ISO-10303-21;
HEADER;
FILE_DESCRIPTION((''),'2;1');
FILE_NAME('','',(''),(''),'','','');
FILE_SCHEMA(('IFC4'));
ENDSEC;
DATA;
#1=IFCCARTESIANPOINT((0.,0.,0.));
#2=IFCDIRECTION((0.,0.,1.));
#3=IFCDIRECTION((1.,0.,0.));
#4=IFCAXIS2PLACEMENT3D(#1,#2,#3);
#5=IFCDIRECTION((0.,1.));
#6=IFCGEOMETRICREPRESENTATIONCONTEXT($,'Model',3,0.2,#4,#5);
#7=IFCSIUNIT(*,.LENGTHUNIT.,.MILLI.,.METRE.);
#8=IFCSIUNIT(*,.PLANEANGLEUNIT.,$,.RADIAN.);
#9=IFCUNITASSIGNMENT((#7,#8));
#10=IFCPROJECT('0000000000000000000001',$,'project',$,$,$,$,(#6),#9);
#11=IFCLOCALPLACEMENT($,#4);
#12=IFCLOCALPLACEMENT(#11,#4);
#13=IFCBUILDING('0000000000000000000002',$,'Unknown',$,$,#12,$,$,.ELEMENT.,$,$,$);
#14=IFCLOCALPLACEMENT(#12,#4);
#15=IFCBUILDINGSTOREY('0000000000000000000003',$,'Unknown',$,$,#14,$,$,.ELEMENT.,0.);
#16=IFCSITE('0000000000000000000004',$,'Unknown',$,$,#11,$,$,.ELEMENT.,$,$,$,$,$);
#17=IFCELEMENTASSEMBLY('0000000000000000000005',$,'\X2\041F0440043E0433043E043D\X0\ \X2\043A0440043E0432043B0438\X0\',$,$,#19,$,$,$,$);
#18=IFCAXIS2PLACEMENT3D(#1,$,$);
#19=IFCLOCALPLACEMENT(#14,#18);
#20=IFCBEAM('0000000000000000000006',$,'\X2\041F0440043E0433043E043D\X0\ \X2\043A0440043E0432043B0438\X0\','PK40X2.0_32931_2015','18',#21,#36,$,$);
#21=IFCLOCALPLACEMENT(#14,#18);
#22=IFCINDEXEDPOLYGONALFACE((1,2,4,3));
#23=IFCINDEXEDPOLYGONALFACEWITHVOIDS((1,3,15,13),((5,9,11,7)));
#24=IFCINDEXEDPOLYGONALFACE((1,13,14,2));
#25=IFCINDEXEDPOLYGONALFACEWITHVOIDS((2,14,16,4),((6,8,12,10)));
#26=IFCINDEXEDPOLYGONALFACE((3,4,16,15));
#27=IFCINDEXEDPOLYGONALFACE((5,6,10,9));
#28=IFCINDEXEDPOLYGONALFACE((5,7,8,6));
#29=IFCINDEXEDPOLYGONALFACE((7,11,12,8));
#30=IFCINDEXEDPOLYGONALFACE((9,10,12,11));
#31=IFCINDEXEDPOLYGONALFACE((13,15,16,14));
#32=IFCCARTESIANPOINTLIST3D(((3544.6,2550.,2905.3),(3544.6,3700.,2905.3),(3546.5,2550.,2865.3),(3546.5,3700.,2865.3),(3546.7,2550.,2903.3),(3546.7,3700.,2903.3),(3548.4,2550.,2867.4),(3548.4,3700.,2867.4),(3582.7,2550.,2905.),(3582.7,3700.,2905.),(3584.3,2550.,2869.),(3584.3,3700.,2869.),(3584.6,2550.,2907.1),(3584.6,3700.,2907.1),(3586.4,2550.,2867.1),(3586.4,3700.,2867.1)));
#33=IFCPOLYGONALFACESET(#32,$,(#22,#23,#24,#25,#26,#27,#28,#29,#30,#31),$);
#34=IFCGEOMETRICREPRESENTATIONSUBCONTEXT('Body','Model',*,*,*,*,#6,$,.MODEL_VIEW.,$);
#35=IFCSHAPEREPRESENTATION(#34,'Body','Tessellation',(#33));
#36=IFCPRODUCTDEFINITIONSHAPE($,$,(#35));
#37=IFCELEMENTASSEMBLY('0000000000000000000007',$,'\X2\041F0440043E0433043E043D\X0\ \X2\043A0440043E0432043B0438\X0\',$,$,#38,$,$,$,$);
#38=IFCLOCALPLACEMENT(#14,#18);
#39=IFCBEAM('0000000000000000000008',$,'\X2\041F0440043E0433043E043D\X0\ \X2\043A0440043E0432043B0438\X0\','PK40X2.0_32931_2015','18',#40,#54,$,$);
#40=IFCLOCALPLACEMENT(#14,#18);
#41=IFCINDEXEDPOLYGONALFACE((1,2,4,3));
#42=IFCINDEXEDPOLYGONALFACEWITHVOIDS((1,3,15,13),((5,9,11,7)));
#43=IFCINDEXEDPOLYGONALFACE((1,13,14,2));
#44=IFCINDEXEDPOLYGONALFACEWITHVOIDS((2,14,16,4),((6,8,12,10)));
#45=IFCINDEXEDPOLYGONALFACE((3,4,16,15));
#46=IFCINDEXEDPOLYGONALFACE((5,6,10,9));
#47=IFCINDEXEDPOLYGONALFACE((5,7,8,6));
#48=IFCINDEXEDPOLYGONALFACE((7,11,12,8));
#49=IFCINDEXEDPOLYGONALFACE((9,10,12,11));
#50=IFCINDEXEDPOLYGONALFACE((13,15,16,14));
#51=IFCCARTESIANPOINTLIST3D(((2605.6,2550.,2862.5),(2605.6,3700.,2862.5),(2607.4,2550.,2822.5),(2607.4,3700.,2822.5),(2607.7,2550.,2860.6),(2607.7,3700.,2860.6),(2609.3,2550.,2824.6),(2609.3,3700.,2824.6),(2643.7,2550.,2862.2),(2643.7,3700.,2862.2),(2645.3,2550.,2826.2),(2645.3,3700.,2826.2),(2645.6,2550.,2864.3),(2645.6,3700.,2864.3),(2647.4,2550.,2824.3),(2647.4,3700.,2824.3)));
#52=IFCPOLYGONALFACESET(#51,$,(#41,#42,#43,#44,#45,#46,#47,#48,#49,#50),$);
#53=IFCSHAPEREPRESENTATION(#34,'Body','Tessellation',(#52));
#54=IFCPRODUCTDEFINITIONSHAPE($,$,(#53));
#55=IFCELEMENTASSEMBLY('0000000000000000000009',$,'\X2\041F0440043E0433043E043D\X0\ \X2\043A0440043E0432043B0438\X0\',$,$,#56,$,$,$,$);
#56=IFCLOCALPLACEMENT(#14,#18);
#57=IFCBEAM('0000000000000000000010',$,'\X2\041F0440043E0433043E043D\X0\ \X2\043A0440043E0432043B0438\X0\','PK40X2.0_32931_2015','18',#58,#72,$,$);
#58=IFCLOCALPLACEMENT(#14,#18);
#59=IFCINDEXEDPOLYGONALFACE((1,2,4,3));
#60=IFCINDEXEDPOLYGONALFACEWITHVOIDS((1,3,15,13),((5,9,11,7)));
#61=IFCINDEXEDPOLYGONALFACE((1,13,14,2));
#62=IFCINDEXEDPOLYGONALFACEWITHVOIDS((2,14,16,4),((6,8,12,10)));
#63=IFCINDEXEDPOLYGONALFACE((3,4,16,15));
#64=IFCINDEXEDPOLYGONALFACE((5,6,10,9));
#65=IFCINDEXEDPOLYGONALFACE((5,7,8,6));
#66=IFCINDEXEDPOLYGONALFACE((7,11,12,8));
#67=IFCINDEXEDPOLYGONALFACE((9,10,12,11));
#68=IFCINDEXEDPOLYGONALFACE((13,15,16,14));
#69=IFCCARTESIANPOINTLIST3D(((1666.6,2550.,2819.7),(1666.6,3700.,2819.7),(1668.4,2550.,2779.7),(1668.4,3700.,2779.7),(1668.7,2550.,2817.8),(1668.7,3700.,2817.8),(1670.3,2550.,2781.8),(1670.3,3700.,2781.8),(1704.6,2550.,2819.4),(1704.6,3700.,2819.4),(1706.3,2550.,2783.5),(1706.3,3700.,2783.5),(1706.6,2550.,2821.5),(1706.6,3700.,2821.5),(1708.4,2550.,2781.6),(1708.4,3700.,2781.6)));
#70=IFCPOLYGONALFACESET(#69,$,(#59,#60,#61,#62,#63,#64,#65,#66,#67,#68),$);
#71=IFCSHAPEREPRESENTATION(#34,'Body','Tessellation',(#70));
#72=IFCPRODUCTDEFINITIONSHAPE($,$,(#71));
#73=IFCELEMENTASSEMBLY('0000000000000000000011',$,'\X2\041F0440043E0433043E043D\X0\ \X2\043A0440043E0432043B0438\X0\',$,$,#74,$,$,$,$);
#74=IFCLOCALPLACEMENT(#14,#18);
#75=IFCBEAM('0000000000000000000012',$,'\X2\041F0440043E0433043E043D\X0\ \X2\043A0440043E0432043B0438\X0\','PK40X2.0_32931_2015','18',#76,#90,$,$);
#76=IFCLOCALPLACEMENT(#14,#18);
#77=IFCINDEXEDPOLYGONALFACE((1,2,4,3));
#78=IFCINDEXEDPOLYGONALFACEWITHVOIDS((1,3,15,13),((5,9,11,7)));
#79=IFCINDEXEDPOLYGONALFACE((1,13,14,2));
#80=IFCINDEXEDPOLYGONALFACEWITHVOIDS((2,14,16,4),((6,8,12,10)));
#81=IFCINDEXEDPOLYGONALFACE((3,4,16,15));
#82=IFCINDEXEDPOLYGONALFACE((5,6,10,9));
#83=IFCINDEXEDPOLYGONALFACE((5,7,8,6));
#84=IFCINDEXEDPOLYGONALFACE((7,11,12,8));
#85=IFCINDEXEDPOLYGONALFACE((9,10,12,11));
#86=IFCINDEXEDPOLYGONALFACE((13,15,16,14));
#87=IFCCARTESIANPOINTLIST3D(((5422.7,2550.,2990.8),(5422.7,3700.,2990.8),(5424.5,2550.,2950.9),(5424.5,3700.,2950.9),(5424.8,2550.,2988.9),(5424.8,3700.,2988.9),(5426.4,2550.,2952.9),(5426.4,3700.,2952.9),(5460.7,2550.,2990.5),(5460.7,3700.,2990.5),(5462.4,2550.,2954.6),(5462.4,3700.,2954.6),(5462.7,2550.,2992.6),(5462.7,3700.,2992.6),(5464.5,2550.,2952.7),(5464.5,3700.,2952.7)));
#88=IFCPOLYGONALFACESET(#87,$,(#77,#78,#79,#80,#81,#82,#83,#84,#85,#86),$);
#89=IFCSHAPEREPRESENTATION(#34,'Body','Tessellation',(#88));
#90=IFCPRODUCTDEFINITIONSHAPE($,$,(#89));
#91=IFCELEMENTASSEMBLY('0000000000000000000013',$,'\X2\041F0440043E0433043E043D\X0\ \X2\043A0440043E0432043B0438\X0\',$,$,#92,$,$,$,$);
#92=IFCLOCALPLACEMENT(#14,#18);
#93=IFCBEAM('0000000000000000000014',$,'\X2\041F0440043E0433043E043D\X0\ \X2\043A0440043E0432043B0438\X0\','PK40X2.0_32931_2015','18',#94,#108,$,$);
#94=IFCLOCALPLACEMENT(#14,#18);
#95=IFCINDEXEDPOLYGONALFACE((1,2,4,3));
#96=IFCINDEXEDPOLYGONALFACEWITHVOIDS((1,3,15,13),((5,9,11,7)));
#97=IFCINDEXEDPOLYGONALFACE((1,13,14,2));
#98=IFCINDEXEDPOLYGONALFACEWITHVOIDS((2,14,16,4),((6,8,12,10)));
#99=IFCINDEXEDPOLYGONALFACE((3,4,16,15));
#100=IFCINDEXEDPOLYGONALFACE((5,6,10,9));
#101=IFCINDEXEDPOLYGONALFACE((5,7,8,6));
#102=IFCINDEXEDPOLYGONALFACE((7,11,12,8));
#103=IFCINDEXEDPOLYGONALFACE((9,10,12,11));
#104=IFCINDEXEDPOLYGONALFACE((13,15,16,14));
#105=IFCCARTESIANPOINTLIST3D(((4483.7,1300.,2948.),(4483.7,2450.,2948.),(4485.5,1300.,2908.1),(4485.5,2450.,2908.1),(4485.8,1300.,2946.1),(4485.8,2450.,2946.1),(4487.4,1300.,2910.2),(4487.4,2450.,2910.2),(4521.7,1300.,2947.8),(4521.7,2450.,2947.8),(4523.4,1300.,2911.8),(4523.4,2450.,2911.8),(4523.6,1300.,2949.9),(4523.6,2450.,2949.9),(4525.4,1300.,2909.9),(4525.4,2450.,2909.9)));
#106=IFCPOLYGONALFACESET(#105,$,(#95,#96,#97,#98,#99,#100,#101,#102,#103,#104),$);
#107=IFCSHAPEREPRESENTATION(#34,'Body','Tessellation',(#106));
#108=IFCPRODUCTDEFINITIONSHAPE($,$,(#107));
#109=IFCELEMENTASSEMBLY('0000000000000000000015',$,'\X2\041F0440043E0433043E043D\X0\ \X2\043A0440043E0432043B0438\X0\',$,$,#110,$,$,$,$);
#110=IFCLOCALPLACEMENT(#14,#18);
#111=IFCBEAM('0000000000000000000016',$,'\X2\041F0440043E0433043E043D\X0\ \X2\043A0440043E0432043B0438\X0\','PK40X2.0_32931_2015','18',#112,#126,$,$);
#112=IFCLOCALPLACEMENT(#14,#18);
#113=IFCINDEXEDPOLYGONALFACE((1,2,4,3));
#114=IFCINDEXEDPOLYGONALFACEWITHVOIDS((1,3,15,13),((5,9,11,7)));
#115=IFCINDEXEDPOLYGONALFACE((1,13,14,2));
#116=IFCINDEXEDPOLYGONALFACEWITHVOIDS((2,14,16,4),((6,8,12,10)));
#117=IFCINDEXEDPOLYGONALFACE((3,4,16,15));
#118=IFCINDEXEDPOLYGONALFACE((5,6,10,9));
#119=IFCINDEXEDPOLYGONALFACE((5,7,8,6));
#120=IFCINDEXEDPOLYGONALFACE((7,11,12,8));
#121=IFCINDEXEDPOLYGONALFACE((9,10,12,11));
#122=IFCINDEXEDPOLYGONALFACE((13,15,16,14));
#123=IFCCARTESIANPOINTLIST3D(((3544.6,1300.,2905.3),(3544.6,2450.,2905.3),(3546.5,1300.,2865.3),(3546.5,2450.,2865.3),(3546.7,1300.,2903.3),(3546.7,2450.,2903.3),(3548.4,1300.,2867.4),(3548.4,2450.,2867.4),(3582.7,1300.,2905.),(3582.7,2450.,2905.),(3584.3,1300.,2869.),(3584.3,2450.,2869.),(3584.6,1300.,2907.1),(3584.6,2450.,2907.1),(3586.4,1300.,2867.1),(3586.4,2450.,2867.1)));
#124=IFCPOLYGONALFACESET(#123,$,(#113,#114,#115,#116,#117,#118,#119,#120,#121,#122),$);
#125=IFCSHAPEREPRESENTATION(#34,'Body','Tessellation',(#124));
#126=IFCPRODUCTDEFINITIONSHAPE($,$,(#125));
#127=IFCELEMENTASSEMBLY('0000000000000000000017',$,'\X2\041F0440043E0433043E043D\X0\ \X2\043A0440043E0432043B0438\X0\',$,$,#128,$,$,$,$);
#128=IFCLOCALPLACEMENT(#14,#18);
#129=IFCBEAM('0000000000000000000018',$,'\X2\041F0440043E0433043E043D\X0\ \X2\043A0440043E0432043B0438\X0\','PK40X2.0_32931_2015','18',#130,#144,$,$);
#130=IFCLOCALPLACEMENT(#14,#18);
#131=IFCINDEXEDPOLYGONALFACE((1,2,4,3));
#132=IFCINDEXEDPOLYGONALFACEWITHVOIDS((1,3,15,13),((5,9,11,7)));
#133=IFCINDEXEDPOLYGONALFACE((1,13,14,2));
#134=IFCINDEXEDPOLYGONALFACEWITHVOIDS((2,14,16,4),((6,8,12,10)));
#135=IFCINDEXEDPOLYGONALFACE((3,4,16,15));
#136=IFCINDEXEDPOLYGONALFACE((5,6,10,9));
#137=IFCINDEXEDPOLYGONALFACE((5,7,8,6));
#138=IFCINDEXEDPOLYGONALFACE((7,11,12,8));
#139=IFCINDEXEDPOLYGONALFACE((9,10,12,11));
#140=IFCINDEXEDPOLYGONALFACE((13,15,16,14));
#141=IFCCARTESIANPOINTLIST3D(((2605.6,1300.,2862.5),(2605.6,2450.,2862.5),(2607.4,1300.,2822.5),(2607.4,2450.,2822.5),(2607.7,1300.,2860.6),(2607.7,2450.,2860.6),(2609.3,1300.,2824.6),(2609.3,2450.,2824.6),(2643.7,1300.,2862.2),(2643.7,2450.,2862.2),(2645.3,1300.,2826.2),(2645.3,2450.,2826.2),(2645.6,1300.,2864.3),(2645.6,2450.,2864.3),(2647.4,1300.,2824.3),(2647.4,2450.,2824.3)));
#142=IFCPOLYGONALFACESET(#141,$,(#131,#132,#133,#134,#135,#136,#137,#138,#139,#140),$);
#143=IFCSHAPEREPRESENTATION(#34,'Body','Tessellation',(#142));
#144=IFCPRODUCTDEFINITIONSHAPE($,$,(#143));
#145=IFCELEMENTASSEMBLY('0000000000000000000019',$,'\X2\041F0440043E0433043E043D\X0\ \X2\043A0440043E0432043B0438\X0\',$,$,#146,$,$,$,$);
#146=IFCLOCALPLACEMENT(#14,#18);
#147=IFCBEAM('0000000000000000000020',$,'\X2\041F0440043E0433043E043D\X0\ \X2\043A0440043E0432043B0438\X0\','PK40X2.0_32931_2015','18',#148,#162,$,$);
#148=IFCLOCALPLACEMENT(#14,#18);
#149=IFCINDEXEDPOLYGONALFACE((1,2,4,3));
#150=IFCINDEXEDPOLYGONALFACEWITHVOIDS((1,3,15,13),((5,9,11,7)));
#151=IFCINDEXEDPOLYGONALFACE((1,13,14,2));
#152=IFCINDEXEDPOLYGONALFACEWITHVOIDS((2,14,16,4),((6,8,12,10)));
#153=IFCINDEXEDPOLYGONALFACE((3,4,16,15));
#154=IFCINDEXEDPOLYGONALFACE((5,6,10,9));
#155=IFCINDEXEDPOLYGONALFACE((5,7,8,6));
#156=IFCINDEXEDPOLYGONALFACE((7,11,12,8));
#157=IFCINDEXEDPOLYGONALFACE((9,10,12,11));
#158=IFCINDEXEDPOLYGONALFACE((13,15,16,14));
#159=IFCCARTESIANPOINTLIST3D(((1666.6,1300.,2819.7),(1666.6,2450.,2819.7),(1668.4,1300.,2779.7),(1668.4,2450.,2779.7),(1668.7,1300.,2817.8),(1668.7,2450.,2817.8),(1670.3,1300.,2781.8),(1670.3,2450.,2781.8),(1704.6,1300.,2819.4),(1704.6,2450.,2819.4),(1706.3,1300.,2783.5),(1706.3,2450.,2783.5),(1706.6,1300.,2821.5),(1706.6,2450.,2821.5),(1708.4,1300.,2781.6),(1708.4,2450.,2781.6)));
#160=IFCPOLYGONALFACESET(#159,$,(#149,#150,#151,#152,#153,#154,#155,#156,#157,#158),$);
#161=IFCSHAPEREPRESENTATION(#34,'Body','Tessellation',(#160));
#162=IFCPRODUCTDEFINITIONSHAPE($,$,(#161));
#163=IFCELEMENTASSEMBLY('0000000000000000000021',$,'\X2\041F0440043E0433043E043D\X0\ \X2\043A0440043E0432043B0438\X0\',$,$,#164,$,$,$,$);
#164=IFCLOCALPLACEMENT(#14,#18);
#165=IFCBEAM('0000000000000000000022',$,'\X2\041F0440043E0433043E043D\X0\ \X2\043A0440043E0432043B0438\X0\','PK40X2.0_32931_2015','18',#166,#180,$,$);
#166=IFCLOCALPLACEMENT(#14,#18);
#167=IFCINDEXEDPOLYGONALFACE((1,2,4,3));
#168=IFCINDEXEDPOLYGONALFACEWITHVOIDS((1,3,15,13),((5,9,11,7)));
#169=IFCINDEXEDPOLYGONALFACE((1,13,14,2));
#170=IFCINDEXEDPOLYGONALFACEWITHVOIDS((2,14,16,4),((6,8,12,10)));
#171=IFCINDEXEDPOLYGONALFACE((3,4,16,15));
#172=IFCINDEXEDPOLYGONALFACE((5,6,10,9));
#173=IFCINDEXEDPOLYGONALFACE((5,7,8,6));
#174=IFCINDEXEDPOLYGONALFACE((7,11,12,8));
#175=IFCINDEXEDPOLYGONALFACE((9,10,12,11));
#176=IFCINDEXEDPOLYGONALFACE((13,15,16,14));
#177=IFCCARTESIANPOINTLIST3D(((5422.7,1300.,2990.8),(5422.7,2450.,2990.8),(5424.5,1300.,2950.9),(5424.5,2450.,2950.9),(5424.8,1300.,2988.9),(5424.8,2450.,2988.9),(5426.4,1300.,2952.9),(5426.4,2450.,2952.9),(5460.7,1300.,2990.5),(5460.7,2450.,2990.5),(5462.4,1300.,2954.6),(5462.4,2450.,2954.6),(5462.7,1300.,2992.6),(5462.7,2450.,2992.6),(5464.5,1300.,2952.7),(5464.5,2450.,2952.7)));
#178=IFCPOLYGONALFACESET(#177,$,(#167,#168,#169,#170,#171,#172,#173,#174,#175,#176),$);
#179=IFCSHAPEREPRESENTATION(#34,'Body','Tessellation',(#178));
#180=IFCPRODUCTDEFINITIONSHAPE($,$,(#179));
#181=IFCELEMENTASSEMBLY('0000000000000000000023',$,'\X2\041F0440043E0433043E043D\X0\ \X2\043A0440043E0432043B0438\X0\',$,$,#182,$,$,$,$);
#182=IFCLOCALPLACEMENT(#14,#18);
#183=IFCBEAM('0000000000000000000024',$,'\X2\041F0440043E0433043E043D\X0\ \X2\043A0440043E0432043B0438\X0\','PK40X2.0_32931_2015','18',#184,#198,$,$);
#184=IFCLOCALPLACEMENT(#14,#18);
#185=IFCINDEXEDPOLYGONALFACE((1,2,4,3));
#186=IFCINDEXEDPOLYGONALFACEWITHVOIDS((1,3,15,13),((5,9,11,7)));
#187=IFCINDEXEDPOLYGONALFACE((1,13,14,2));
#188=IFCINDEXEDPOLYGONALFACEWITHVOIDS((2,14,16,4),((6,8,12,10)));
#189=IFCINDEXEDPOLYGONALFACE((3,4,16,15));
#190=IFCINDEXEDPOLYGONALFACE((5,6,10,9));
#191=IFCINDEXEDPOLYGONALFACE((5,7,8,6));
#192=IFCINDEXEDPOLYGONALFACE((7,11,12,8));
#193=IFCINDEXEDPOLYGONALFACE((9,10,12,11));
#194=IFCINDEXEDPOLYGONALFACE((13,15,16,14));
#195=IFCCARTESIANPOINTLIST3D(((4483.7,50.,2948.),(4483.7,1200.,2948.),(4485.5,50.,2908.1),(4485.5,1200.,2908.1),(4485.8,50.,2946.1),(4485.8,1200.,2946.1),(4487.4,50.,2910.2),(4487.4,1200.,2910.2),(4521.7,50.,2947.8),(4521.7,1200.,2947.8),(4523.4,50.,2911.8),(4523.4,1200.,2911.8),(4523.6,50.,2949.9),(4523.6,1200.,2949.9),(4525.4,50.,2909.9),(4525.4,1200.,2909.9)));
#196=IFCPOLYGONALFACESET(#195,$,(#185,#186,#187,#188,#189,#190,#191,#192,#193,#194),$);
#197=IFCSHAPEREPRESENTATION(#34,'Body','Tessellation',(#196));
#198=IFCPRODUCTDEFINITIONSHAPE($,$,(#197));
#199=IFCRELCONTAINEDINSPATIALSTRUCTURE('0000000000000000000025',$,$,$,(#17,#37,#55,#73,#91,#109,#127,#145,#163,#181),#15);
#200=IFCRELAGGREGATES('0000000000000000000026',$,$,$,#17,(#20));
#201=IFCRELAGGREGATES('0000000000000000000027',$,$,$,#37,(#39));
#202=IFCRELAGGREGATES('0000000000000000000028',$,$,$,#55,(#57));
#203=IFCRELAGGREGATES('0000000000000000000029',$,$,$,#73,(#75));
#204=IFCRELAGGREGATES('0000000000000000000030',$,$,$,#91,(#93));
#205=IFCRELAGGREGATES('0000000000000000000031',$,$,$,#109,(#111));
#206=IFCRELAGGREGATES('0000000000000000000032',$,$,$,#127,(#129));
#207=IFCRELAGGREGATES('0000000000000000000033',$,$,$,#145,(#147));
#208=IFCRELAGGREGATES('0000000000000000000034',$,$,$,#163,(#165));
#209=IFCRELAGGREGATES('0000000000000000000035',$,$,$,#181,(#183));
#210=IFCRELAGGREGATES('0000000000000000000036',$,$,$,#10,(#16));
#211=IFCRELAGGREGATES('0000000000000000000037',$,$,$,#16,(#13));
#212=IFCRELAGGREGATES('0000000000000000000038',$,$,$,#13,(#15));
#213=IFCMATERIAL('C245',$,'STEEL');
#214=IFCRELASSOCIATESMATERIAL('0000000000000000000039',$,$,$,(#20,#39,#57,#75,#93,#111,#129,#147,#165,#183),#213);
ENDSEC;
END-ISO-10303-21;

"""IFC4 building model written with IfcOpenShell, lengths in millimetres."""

from ifc_helpers import new_model, si_unit, direction, frame, origin_with_axes, place, context, subcontext, project, spatial, line, indexed_curve, outline, extrude, material, element, aggregate, save


model = new_model("IFC4")

# Units and contexts
model_context = context("Model", 3, precision=0.2, world=origin_with_axes(), true_north=direction((0.0, 1.0)))
body_context = subcontext(model_context, "Body", "Model", "MODEL_VIEW")
ifc_project = project(units=[si_unit("LENGTHUNIT", "METRE", prefix="MILLI"), si_unit("PLANEANGLEUNIT", "RADIAN")], contexts=[model_context])

# Site, building, storey
site_placement = place(None, origin_with_axes())
site = spatial("IfcSite", under=ifc_project, at=site_placement, Name="Unknown", CompositionType="ELEMENT")
building_placement = place(site_placement, origin_with_axes())
building = spatial("IfcBuilding", under=site, at=building_placement, Name="Unknown", CompositionType="ELEMENT")
storey_placement = place(building_placement, origin_with_axes())
storey = spatial("IfcBuildingStorey", under=building, at=storey_placement, Name="Unknown", CompositionType="ELEMENT", Elevation=0.0)

# Shared definitions
ifc_material = material(Name="C245", Category="STEEL")

# Element assemblies, beams
assembly_1_placement = place(storey_placement, frame((3565.5, 3700.0, 2886.2), z_axis=(-0.998964, 0.0, -0.045508), x_axis=(0.0, -1.0, 0.0)))
assembly_1 = element("IfcElementAssembly", 1, at=assembly_1_placement, inside=storey, Name="Прогон кровли")
beam_1_placement = place(assembly_1_placement, origin_with_axes())
beam_1 = element("IfcBeam", 2, at=beam_1_placement, material=ifc_material, Name="Прогон кровли", Description="PK40X2.0_32931_2015", ObjectType="18", context=body_context, shape_type="SolidModel", body=[
    extrude(outline(indexed_curve([(-20.0, -20.0), (20.0, -20.0), (20.0, 20.0), (-20.0, 20.0)], segments=[line(1, 2, 3, 4, 1)]), holes=[indexed_curve([(-18.0, -18.0), (-18.0, 18.0), (18.0, 18.0), (18.0, -18.0)], segments=[line(1, 2, 3, 4, 1)])]), frame((0.0, 0.0, 0.0), z_axis=(-1.0, 0.0, 0.0), x_axis=(0.0, 0.0, 1.0)), (0.0, 0.0, -1.0), 1150.0),
])
aggregate(assembly_1, [beam_1])
assembly_2_placement = place(storey_placement, frame((2626.5, 3700.0, 2843.4), z_axis=(-0.998964, 0.0, -0.045508), x_axis=(0.0, -1.0, 0.0)))
assembly_2 = element("IfcElementAssembly", 3, at=assembly_2_placement, inside=storey, Name="Прогон кровли")
beam_2_placement = place(assembly_2_placement, origin_with_axes())
beam_2 = element("IfcBeam", 4, at=beam_2_placement, material=ifc_material, Name="Прогон кровли", Description="PK40X2.0_32931_2015", ObjectType="18", context=body_context, shape_type="SolidModel", body=[
    extrude(outline(indexed_curve([(-20.0, -20.0), (20.0, -20.0), (20.0, 20.0), (-20.0, 20.0)], segments=[line(1, 2, 3, 4, 1)]), holes=[indexed_curve([(-18.0, -18.0), (-18.0, 18.0), (18.0, 18.0), (18.0, -18.0)], segments=[line(1, 2, 3, 4, 1)])]), frame((0.0, 0.0, 0.0), z_axis=(-1.0, 0.0, 0.0), x_axis=(0.0, 0.0, 1.0)), (0.0, 0.0, -1.0), 1150.0),
])
aggregate(assembly_2, [beam_2])
assembly_3_placement = place(storey_placement, frame((1687.5, 3700.0, 2800.6), z_axis=(-0.998964, 0.0, -0.045508), x_axis=(0.0, -1.0, 0.0)))
assembly_3 = element("IfcElementAssembly", 5, at=assembly_3_placement, inside=storey, Name="Прогон кровли")
beam_3_placement = place(assembly_3_placement, origin_with_axes())
beam_3 = element("IfcBeam", 6, at=beam_3_placement, material=ifc_material, Name="Прогон кровли", Description="PK40X2.0_32931_2015", ObjectType="18", context=body_context, shape_type="SolidModel", body=[
    extrude(outline(indexed_curve([(-20.0, -20.0), (20.0, -20.0), (20.0, 20.0), (-20.0, 20.0)], segments=[line(1, 2, 3, 4, 1)]), holes=[indexed_curve([(-18.0, -18.0), (-18.0, 18.0), (18.0, 18.0), (18.0, -18.0)], segments=[line(1, 2, 3, 4, 1)])]), frame((0.0, 0.0, 0.0), z_axis=(-1.0, 0.0, 0.0), x_axis=(0.0, 0.0, 1.0)), (0.0, 0.0, -1.0), 1150.0),
])
aggregate(assembly_3, [beam_3])
assembly_4_placement = place(storey_placement, frame((5443.6, 3700.0, 2971.7), z_axis=(-0.998964, 0.0, -0.045508), x_axis=(0.0, -1.0, 0.0)))
assembly_4 = element("IfcElementAssembly", 7, at=assembly_4_placement, inside=storey, Name="Прогон кровли")
beam_4_placement = place(assembly_4_placement, origin_with_axes())
beam_4 = element("IfcBeam", 8, at=beam_4_placement, material=ifc_material, Name="Прогон кровли", Description="PK40X2.0_32931_2015", ObjectType="18", context=body_context, shape_type="SolidModel", body=[
    extrude(outline(indexed_curve([(-20.0, -20.0), (20.0, -20.0), (20.0, 20.0), (-20.0, 20.0)], segments=[line(1, 2, 3, 4, 1)]), holes=[indexed_curve([(-18.0, -18.0), (-18.0, 18.0), (18.0, 18.0), (18.0, -18.0)], segments=[line(1, 2, 3, 4, 1)])]), frame((0.0, 0.0, 0.0), z_axis=(-1.0, 0.0, 0.0), x_axis=(0.0, 0.0, 1.0)), (0.0, 0.0, -1.0), 1150.0),
])
aggregate(assembly_4, [beam_4])
assembly_5_placement = place(storey_placement, frame((4504.6, 2450.0, 2929.0), z_axis=(-0.998964, 0.0, -0.045508), x_axis=(0.0, -1.0, 0.0)))
assembly_5 = element("IfcElementAssembly", 9, at=assembly_5_placement, inside=storey, Name="Прогон кровли")
beam_5_placement = place(assembly_5_placement, origin_with_axes())
beam_5 = element("IfcBeam", 10, at=beam_5_placement, material=ifc_material, Name="Прогон кровли", Description="PK40X2.0_32931_2015", ObjectType="18", context=body_context, shape_type="SolidModel", body=[
    extrude(outline(indexed_curve([(-20.0, -20.0), (20.0, -20.0), (20.0, 20.0), (-20.0, 20.0)], segments=[line(1, 2, 3, 4, 1)]), holes=[indexed_curve([(-18.0, -18.0), (-18.0, 18.0), (18.0, 18.0), (18.0, -18.0)], segments=[line(1, 2, 3, 4, 1)])]), frame((0.0, 0.0, 0.0), z_axis=(-1.0, 0.0, 0.0), x_axis=(0.0, 0.0, 1.0)), (0.0, 0.0, -1.0), 1150.0),
])
aggregate(assembly_5, [beam_5])
assembly_6_placement = place(storey_placement, frame((3565.5, 2450.0, 2886.2), z_axis=(-0.998964, 0.0, -0.045508), x_axis=(0.0, -1.0, 0.0)))
assembly_6 = element("IfcElementAssembly", 11, at=assembly_6_placement, inside=storey, Name="Прогон кровли")
beam_6_placement = place(assembly_6_placement, origin_with_axes())
beam_6 = element("IfcBeam", 12, at=beam_6_placement, material=ifc_material, Name="Прогон кровли", Description="PK40X2.0_32931_2015", ObjectType="18", context=body_context, shape_type="SolidModel", body=[
    extrude(outline(indexed_curve([(-20.0, -20.0), (20.0, -20.0), (20.0, 20.0), (-20.0, 20.0)], segments=[line(1, 2, 3, 4, 1)]), holes=[indexed_curve([(-18.0, -18.0), (-18.0, 18.0), (18.0, 18.0), (18.0, -18.0)], segments=[line(1, 2, 3, 4, 1)])]), frame((0.0, 0.0, 0.0), z_axis=(-1.0, 0.0, 0.0), x_axis=(0.0, 0.0, 1.0)), (0.0, 0.0, -1.0), 1150.0),
])
aggregate(assembly_6, [beam_6])
assembly_7_placement = place(storey_placement, frame((2626.5, 2450.0, 2843.4), z_axis=(-0.998964, 0.0, -0.045508), x_axis=(0.0, -1.0, 0.0)))
assembly_7 = element("IfcElementAssembly", 13, at=assembly_7_placement, inside=storey, Name="Прогон кровли")
beam_7_placement = place(assembly_7_placement, origin_with_axes())
beam_7 = element("IfcBeam", 14, at=beam_7_placement, material=ifc_material, Name="Прогон кровли", Description="PK40X2.0_32931_2015", ObjectType="18", context=body_context, shape_type="SolidModel", body=[
    extrude(outline(indexed_curve([(-20.0, -20.0), (20.0, -20.0), (20.0, 20.0), (-20.0, 20.0)], segments=[line(1, 2, 3, 4, 1)]), holes=[indexed_curve([(-18.0, -18.0), (-18.0, 18.0), (18.0, 18.0), (18.0, -18.0)], segments=[line(1, 2, 3, 4, 1)])]), frame((0.0, 0.0, 0.0), z_axis=(-1.0, 0.0, 0.0), x_axis=(0.0, 0.0, 1.0)), (0.0, 0.0, -1.0), 1150.0),
])
aggregate(assembly_7, [beam_7])
assembly_8_placement = place(storey_placement, frame((1687.5, 2450.0, 2800.6), z_axis=(-0.998964, 0.0, -0.045508), x_axis=(0.0, -1.0, 0.0)))
assembly_8 = element("IfcElementAssembly", 15, at=assembly_8_placement, inside=storey, Name="Прогон кровли")
beam_8_placement = place(assembly_8_placement, origin_with_axes())
beam_8 = element("IfcBeam", 16, at=beam_8_placement, material=ifc_material, Name="Прогон кровли", Description="PK40X2.0_32931_2015", ObjectType="18", context=body_context, shape_type="SolidModel", body=[
    extrude(outline(indexed_curve([(-20.0, -20.0), (20.0, -20.0), (20.0, 20.0), (-20.0, 20.0)], segments=[line(1, 2, 3, 4, 1)]), holes=[indexed_curve([(-18.0, -18.0), (-18.0, 18.0), (18.0, 18.0), (18.0, -18.0)], segments=[line(1, 2, 3, 4, 1)])]), frame((0.0, 0.0, 0.0), z_axis=(-1.0, 0.0, 0.0), x_axis=(0.0, 0.0, 1.0)), (0.0, 0.0, -1.0), 1150.0),
])
aggregate(assembly_8, [beam_8])
assembly_9_placement = place(storey_placement, frame((5443.6, 2450.0, 2971.7), z_axis=(-0.998964, 0.0, -0.045508), x_axis=(0.0, -1.0, 0.0)))
assembly_9 = element("IfcElementAssembly", 17, at=assembly_9_placement, inside=storey, Name="Прогон кровли")
beam_9_placement = place(assembly_9_placement, origin_with_axes())
beam_9 = element("IfcBeam", 18, at=beam_9_placement, material=ifc_material, Name="Прогон кровли", Description="PK40X2.0_32931_2015", ObjectType="18", context=body_context, shape_type="SolidModel", body=[
    extrude(outline(indexed_curve([(-20.0, -20.0), (20.0, -20.0), (20.0, 20.0), (-20.0, 20.0)], segments=[line(1, 2, 3, 4, 1)]), holes=[indexed_curve([(-18.0, -18.0), (-18.0, 18.0), (18.0, 18.0), (18.0, -18.0)], segments=[line(1, 2, 3, 4, 1)])]), frame((0.0, 0.0, 0.0), z_axis=(-1.0, 0.0, 0.0), x_axis=(0.0, 0.0, 1.0)), (0.0, 0.0, -1.0), 1150.0),
])
aggregate(assembly_9, [beam_9])
assembly_10_placement = place(storey_placement, frame((4504.6, 1200.0, 2929.0), z_axis=(-0.998964, 0.0, -0.045508), x_axis=(0.0, -1.0, 0.0)))
assembly_10 = element("IfcElementAssembly", 19, at=assembly_10_placement, inside=storey, Name="Прогон кровли")
beam_10_placement = place(assembly_10_placement, origin_with_axes())
beam_10 = element("IfcBeam", 20, at=beam_10_placement, material=ifc_material, Name="Прогон кровли", Description="PK40X2.0_32931_2015", ObjectType="18", context=body_context, shape_type="SolidModel", body=[
    extrude(outline(indexed_curve([(-20.0, -20.0), (20.0, -20.0), (20.0, 20.0), (-20.0, 20.0)], segments=[line(1, 2, 3, 4, 1)]), holes=[indexed_curve([(-18.0, -18.0), (-18.0, 18.0), (18.0, 18.0), (18.0, -18.0)], segments=[line(1, 2, 3, 4, 1)])]), frame((0.0, 0.0, 0.0), z_axis=(-1.0, 0.0, 0.0), x_axis=(0.0, 0.0, 1.0)), (0.0, 0.0, -1.0), 1150.0),
])
aggregate(assembly_10, [beam_10])

save(model, "model.ifc")
